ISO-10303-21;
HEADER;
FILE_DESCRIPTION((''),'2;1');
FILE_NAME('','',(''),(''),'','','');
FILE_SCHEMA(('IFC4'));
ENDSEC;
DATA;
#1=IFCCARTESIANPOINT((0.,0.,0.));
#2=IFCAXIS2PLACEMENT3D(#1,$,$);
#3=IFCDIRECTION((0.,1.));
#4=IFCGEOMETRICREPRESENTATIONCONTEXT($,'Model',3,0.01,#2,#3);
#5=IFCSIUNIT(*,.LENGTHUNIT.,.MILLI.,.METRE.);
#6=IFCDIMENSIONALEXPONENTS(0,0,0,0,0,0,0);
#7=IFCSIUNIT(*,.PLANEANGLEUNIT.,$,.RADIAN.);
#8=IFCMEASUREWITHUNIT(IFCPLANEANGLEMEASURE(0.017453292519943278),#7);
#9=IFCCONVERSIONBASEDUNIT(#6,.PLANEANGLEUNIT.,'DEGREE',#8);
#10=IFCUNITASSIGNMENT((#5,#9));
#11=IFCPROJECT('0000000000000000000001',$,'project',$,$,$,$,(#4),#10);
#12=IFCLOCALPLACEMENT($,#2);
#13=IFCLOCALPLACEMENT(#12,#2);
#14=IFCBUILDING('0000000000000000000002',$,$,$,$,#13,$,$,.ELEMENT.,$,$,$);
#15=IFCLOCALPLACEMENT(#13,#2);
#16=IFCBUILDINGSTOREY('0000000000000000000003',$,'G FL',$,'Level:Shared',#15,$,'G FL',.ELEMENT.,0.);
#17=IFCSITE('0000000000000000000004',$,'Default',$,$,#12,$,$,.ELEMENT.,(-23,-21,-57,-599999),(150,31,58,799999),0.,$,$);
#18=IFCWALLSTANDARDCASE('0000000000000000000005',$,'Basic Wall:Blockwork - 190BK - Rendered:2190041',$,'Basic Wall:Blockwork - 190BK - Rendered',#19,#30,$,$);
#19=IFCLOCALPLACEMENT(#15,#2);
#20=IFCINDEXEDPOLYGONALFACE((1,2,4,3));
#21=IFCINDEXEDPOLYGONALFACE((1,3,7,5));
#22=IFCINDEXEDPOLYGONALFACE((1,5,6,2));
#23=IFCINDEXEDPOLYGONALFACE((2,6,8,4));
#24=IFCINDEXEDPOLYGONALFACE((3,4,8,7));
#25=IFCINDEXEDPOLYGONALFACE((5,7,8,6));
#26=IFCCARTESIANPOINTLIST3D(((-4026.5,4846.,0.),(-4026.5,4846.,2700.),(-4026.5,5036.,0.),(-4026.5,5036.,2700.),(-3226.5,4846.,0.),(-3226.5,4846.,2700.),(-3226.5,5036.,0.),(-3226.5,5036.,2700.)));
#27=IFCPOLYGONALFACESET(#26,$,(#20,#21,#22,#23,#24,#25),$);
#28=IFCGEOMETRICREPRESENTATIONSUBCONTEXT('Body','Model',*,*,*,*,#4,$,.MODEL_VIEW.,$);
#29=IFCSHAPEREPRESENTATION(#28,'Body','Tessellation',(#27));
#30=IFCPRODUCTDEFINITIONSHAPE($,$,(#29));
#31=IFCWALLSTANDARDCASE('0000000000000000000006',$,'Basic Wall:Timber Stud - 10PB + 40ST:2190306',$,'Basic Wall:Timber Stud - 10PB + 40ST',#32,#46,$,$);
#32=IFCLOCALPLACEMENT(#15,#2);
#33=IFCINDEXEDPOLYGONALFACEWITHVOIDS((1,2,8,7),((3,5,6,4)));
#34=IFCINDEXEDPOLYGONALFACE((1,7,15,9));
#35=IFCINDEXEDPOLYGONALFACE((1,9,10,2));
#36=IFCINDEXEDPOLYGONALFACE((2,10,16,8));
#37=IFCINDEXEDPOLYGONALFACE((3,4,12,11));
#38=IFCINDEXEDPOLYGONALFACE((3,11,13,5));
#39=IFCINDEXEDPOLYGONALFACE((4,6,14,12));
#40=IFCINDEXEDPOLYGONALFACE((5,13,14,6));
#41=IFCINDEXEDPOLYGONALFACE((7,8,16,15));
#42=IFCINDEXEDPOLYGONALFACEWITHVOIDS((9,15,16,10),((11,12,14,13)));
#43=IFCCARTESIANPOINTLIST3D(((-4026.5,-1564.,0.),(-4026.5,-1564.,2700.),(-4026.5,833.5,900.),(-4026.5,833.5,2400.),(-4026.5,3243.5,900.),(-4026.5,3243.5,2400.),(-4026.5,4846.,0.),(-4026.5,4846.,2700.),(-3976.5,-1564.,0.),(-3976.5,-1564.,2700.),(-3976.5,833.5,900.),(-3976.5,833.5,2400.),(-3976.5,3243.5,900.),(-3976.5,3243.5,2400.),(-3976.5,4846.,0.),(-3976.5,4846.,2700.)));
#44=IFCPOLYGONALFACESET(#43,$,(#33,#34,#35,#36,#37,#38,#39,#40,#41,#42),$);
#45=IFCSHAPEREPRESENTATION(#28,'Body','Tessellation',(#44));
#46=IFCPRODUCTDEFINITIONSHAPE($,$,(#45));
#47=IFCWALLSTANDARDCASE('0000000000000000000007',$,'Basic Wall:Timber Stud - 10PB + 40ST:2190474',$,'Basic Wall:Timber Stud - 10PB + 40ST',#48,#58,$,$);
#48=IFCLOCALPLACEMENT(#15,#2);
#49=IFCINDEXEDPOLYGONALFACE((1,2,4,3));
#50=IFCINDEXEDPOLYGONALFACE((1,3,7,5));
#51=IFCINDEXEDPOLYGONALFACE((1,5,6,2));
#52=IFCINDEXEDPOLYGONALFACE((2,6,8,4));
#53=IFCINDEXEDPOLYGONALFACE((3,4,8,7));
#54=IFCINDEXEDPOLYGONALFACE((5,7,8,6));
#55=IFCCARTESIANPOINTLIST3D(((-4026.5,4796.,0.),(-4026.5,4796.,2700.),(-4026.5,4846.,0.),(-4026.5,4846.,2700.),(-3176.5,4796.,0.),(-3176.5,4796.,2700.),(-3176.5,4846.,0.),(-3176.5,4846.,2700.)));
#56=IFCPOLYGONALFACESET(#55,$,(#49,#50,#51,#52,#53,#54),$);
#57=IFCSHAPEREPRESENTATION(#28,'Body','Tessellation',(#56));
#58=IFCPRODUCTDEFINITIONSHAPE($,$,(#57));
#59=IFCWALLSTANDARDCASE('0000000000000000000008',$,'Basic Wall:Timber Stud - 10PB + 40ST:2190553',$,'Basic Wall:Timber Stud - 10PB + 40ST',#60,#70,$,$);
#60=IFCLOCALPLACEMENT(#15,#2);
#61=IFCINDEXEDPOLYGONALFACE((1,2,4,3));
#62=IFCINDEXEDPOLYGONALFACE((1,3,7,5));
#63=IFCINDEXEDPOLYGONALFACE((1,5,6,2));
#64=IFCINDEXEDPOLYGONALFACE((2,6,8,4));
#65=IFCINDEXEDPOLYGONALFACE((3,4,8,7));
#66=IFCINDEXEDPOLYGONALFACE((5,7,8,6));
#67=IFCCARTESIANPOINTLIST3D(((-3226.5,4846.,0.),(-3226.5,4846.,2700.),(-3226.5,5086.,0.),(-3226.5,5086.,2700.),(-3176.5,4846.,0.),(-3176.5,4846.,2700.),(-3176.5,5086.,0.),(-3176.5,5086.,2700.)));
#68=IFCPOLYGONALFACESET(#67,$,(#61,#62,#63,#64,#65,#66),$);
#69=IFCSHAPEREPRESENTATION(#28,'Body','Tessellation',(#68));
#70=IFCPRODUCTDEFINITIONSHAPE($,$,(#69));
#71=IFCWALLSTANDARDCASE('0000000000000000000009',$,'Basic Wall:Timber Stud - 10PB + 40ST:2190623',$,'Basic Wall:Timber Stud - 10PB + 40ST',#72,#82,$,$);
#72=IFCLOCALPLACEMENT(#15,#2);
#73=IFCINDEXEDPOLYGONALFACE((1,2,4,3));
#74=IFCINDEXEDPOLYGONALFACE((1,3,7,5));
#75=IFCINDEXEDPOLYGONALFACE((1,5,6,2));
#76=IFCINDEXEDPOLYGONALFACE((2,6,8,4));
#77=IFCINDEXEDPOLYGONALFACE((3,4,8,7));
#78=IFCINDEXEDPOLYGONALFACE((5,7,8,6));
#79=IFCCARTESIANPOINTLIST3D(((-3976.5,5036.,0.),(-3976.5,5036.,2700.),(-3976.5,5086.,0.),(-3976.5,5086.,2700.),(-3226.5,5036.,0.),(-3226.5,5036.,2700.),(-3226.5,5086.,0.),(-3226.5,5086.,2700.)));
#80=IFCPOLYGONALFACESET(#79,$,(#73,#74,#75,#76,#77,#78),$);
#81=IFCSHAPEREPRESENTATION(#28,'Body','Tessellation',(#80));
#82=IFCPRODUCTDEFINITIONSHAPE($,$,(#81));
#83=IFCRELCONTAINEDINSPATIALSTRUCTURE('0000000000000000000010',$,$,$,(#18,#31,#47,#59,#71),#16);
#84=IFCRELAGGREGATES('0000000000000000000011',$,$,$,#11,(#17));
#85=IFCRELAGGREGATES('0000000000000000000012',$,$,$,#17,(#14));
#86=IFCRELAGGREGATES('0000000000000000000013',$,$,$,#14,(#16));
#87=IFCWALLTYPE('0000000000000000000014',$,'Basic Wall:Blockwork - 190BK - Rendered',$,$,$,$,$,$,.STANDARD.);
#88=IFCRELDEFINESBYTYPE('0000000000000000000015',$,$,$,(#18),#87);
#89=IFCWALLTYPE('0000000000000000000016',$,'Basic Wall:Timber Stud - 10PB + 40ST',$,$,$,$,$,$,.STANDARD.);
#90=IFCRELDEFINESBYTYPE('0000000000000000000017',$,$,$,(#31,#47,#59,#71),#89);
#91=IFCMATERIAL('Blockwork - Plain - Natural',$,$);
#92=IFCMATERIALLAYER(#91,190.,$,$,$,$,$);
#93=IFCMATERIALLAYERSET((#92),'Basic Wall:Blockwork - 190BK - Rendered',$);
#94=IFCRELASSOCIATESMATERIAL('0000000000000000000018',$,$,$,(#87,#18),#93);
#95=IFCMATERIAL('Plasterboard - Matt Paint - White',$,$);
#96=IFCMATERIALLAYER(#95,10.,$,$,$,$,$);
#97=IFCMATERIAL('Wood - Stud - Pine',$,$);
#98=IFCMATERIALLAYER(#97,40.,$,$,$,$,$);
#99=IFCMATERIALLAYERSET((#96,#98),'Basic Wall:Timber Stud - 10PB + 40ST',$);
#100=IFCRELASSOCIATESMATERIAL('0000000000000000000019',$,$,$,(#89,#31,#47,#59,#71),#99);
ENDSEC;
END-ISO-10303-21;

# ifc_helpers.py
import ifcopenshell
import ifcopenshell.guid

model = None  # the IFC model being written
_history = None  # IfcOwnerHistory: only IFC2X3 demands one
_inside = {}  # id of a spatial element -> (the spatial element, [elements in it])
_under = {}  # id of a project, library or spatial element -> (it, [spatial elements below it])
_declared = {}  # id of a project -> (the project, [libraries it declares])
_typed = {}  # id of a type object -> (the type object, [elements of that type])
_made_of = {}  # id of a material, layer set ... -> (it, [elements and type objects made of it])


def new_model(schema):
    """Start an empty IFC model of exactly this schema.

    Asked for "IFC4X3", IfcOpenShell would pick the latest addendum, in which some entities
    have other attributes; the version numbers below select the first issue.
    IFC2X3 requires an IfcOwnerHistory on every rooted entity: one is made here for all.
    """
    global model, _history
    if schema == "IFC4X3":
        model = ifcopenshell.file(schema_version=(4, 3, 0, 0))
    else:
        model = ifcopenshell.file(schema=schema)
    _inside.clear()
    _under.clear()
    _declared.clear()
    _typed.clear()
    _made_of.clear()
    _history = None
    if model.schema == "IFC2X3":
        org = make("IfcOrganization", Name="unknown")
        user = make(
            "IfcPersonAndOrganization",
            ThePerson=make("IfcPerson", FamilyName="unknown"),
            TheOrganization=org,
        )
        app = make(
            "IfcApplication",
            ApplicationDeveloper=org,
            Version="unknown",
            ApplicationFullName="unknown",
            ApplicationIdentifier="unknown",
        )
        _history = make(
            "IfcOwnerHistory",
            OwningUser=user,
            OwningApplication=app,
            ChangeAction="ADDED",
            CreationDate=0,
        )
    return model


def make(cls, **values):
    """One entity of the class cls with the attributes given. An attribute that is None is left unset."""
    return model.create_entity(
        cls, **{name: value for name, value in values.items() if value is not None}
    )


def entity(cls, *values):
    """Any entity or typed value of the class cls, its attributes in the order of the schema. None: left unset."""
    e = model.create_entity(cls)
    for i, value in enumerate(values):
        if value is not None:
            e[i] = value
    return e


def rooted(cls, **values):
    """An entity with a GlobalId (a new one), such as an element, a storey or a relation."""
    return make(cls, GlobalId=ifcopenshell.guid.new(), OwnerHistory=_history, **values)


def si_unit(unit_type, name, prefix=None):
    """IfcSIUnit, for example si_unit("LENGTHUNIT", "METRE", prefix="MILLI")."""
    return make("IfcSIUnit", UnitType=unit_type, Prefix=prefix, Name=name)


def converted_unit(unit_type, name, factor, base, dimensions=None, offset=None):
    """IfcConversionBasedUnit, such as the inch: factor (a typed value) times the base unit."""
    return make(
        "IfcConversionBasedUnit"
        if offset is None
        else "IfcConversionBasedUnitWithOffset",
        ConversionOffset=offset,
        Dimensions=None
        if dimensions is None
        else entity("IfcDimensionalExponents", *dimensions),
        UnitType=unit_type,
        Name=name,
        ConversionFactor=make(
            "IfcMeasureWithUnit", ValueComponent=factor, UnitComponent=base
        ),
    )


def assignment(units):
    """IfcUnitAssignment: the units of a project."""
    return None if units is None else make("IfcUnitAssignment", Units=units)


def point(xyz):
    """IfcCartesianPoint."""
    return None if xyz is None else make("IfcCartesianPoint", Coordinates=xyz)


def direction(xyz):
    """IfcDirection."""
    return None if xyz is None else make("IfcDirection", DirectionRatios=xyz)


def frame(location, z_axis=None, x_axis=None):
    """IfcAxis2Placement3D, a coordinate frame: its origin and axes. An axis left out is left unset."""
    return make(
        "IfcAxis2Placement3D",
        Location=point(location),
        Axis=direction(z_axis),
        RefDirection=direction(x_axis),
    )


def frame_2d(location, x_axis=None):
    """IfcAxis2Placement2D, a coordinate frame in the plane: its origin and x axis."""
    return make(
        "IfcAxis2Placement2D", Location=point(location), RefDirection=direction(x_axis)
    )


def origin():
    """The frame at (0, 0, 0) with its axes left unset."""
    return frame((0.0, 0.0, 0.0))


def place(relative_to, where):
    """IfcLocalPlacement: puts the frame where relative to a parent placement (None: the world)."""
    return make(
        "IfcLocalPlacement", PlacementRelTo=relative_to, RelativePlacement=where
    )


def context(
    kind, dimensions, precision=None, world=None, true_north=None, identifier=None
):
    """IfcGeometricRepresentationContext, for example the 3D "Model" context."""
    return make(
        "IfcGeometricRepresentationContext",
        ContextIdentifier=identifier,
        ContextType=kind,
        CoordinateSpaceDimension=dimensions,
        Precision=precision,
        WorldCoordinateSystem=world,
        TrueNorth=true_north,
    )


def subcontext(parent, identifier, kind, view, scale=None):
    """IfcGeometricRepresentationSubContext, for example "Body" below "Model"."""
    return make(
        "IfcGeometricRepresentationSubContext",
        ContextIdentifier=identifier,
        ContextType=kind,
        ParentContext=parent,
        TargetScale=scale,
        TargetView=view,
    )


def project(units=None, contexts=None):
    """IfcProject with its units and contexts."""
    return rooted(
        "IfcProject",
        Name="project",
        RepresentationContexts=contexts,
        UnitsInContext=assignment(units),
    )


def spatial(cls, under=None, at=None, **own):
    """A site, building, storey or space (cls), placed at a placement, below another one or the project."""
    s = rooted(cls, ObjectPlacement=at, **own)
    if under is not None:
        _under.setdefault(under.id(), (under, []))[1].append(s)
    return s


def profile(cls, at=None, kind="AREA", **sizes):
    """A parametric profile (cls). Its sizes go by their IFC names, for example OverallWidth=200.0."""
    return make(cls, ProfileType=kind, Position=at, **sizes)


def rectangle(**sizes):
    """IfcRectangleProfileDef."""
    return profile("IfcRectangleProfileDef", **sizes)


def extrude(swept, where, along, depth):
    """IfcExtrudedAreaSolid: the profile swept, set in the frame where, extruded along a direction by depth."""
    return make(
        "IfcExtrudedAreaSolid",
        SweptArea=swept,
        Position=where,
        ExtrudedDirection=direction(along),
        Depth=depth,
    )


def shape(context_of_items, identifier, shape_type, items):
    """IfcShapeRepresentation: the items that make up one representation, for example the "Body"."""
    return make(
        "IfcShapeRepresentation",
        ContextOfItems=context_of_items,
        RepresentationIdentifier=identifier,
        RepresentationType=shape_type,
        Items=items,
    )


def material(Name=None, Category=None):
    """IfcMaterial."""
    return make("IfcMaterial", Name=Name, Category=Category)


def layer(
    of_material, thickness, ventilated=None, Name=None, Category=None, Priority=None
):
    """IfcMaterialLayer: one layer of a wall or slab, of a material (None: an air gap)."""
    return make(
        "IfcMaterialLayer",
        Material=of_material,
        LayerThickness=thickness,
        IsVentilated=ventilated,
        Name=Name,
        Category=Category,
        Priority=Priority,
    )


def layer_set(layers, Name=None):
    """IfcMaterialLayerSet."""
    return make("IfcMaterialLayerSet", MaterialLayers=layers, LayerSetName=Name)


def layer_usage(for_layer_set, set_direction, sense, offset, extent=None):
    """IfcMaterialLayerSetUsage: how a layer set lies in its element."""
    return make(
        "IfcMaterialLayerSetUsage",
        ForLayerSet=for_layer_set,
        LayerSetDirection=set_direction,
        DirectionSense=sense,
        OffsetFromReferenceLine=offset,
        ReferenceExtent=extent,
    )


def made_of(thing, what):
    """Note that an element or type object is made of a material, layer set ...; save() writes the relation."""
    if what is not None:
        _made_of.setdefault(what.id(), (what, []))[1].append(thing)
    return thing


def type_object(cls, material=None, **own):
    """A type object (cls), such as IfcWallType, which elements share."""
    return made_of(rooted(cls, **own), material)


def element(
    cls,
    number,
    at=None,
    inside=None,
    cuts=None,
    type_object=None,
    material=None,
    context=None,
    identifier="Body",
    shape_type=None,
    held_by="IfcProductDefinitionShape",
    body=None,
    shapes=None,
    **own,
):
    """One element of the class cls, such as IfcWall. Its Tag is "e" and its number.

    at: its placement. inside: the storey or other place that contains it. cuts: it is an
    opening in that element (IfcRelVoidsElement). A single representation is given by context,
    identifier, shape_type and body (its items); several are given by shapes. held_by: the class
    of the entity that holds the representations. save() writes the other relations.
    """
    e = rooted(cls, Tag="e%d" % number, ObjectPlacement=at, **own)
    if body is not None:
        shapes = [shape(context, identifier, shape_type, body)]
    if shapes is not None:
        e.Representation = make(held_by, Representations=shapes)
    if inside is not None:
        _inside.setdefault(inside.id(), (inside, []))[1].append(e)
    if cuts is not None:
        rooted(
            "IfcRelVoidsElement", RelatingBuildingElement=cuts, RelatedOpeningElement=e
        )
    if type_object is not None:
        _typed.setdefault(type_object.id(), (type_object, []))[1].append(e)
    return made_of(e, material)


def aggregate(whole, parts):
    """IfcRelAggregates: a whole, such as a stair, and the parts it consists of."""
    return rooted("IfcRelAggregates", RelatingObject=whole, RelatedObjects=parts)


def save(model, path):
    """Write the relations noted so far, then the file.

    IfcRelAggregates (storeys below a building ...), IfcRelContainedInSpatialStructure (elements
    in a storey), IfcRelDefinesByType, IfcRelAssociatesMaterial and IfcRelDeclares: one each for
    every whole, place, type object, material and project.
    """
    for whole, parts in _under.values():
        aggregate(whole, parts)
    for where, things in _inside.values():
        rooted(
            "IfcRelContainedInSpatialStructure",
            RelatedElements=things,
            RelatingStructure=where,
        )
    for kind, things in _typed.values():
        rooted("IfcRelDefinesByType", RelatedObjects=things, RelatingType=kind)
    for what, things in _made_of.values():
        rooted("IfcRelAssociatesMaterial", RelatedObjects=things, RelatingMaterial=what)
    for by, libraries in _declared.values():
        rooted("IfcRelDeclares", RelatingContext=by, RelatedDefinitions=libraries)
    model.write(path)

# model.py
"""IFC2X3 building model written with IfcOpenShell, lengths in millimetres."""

from ifc_helpers import new_model, entity, si_unit, converted_unit, direction, frame, frame_2d, origin, place, context, subcontext, project, spatial, rectangle, extrude, material, layer, layer_set, layer_usage, type_object, element, save


model = new_model("IFC2X3")

# Units and contexts
model_context = context("Model", 3, precision=0.01, world=origin(), true_north=direction((0.0, 1.0)))
body_context = subcontext(model_context, "Body", "Model", "MODEL_VIEW")
ifc_project = project(units=[si_unit("LENGTHUNIT", "METRE", prefix="MILLI"), converted_unit("PLANEANGLEUNIT", "DEGREE", entity("IfcPlaneAngleMeasure", 0.017453292519943278), si_unit("PLANEANGLEUNIT", "RADIAN"), dimensions=[0, 0, 0, 0, 0, 0, 0])], contexts=[model_context])

# Site, building, storey
site_placement = place(None, origin())
site = spatial("IfcSite", under=ifc_project, at=site_placement, Name="Default", CompositionType="ELEMENT", RefLatitude=(-23, -21, -57, -599999), RefLongitude=(150, 31, 58, 799999), RefElevation=0.0)
building_placement = place(site_placement, origin())
building = spatial("IfcBuilding", under=site, at=building_placement, CompositionType="ELEMENT")
storey_placement = place(building_placement, origin())
storey = spatial("IfcBuildingStorey", under=building, at=storey_placement, Name="G FL", ObjectType="Level:Shared", LongName="G FL", CompositionType="ELEMENT", Elevation=0.0)

# Wall
ifc_material_1 = material(Name="Blockwork - Plain - Natural")
ifc_layer_1 = layer(ifc_material_1, 190.0)
ifc_layer_set_1 = layer_set([ifc_layer_1], Name="Basic Wall:Blockwork - 190BK - Rendered")
ifc_layer_usage_1 = layer_usage(ifc_layer_set_1, "AXIS2", "POSITIVE", -95.0)
wall_type_1 = type_object("IfcWallType", Name="Basic Wall:Blockwork - 190BK - Rendered", PredefinedType="STANDARD", material=ifc_layer_set_1)
wall_1_placement = place(storey_placement, frame((-4026.5, 4941.0, 0.0)))
element("IfcWallStandardCase", 1, at=wall_1_placement, inside=storey, type_object=wall_type_1, material=ifc_layer_usage_1, Name="Basic Wall:Blockwork - 190BK - Rendered:2190041", ObjectType="Basic Wall:Blockwork - 190BK - Rendered", context=body_context, shape_type="SweptSolid", body=[
    extrude(rectangle(XDim=800.0, YDim=190.0, at=frame_2d((400.0, 0.0), x_axis=(-1.0, 0.0))), origin(), (0.0, 0.0, 1.0), 2700.0),
])

# Wall, opening
ifc_material_2 = material(Name="Plasterboard - Matt Paint - White")
ifc_layer_2 = layer(ifc_material_2, 10.0)
ifc_material_3 = material(Name="Wood - Stud - Pine")
ifc_layer_3 = layer(ifc_material_3, 40.0)
ifc_layer_set_2 = layer_set([ifc_layer_2, ifc_layer_3], Name="Basic Wall:Timber Stud - 10PB + 40ST")
ifc_layer_usage_2 = layer_usage(ifc_layer_set_2, "AXIS2", "NEGATIVE", 25.0)
wall_type_2 = type_object("IfcWallType", Name="Basic Wall:Timber Stud - 10PB + 40ST", PredefinedType="STANDARD", material=ifc_layer_set_2)
wall_2_placement = place(storey_placement, frame((-4001.5, 4846.0, 0.0), z_axis=(0.0, 0.0, 1.0), x_axis=(0.0, -1.0, 0.0)))
wall_2 = element("IfcWallStandardCase", 2, at=wall_2_placement, inside=storey, type_object=wall_type_2, material=ifc_layer_usage_2, Name="Basic Wall:Timber Stud - 10PB + 40ST:2190306", ObjectType="Basic Wall:Timber Stud - 10PB + 40ST", context=body_context, shape_type="SweptSolid", body=[
    extrude(rectangle(XDim=6410.0, YDim=50.0, at=frame_2d((3205.0, 0.0), x_axis=(-1.0, 0.0))), origin(), (0.0, 0.0, 1.0), 2700.0),
])
opening_placement = place(wall_2_placement, origin())
element("IfcOpeningElement", 3, at=opening_placement, cuts=wall_2, ObjectType="Opening", context=body_context, shape_type="SweptSolid", body=[
    extrude(rectangle(XDim=1500.0, YDim=2410.0, at=frame_2d((0.0, 0.0), x_axis=(0.0, 1.0))), frame((2807.5, -1549.0, 1650.0), z_axis=(0.0, 1.0, 0.0), x_axis=(1.0, 0.0, 0.0)), (0.0, 0.0, 1.0), 3048.0),
])

# Walls
ifc_layer_usage_3 = layer_usage(ifc_layer_set_2, "AXIS2", "POSITIVE", -25.0)
wall_3_placement = place(storey_placement, frame((-4026.5, 4821.0, 0.0)))
element("IfcWallStandardCase", 4, at=wall_3_placement, inside=storey, type_object=wall_type_2, material=ifc_layer_usage_3, Name="Basic Wall:Timber Stud - 10PB + 40ST:2190474", ObjectType="Basic Wall:Timber Stud - 10PB + 40ST", context=body_context, shape_type="SweptSolid", body=[
    extrude(rectangle(XDim=850.0, YDim=50.0, at=frame_2d((425.0, 0.0), x_axis=(-1.0, 0.0))), origin(), (0.0, 0.0, 1.0), 2700.0),
])
ifc_layer_usage_4 = layer_usage(ifc_layer_set_2, "AXIS2", "NEGATIVE", 25.0)
wall_4_placement = place(storey_placement, frame((-3201.5, 5086.0, 0.0), z_axis=(0.0, 0.0, 1.0), x_axis=(0.0, -1.0, 0.0)))
element("IfcWallStandardCase", 5, at=wall_4_placement, inside=storey, type_object=wall_type_2, material=ifc_layer_usage_4, Name="Basic Wall:Timber Stud - 10PB + 40ST:2190553", ObjectType="Basic Wall:Timber Stud - 10PB + 40ST", context=body_context, shape_type="SweptSolid", body=[
    extrude(rectangle(XDim=240.0, YDim=50.0, at=frame_2d((120.0, 0.0), x_axis=(-1.0, 0.0))), origin(), (0.0, 0.0, 1.0), 2700.0),
])
ifc_layer_usage_5 = layer_usage(ifc_layer_set_2, "AXIS2", "POSITIVE", -25.0)
wall_5_placement = place(storey_placement, frame((-3226.5, 5061.0, 0.0), z_axis=(0.0, 0.0, 1.0), x_axis=(-1.0, 0.0, 0.0)))
element("IfcWallStandardCase", 6, at=wall_5_placement, inside=storey, type_object=wall_type_2, material=ifc_layer_usage_5, Name="Basic Wall:Timber Stud - 10PB + 40ST:2190623", ObjectType="Basic Wall:Timber Stud - 10PB + 40ST", context=body_context, shape_type="SweptSolid", body=[
    extrude(rectangle(XDim=750.0, YDim=50.0, at=frame_2d((375.0, 0.0), x_axis=(-1.0, 0.0))), origin(), (0.0, 0.0, 1.0), 2700.0),
])

save(model, "model.ifc")
